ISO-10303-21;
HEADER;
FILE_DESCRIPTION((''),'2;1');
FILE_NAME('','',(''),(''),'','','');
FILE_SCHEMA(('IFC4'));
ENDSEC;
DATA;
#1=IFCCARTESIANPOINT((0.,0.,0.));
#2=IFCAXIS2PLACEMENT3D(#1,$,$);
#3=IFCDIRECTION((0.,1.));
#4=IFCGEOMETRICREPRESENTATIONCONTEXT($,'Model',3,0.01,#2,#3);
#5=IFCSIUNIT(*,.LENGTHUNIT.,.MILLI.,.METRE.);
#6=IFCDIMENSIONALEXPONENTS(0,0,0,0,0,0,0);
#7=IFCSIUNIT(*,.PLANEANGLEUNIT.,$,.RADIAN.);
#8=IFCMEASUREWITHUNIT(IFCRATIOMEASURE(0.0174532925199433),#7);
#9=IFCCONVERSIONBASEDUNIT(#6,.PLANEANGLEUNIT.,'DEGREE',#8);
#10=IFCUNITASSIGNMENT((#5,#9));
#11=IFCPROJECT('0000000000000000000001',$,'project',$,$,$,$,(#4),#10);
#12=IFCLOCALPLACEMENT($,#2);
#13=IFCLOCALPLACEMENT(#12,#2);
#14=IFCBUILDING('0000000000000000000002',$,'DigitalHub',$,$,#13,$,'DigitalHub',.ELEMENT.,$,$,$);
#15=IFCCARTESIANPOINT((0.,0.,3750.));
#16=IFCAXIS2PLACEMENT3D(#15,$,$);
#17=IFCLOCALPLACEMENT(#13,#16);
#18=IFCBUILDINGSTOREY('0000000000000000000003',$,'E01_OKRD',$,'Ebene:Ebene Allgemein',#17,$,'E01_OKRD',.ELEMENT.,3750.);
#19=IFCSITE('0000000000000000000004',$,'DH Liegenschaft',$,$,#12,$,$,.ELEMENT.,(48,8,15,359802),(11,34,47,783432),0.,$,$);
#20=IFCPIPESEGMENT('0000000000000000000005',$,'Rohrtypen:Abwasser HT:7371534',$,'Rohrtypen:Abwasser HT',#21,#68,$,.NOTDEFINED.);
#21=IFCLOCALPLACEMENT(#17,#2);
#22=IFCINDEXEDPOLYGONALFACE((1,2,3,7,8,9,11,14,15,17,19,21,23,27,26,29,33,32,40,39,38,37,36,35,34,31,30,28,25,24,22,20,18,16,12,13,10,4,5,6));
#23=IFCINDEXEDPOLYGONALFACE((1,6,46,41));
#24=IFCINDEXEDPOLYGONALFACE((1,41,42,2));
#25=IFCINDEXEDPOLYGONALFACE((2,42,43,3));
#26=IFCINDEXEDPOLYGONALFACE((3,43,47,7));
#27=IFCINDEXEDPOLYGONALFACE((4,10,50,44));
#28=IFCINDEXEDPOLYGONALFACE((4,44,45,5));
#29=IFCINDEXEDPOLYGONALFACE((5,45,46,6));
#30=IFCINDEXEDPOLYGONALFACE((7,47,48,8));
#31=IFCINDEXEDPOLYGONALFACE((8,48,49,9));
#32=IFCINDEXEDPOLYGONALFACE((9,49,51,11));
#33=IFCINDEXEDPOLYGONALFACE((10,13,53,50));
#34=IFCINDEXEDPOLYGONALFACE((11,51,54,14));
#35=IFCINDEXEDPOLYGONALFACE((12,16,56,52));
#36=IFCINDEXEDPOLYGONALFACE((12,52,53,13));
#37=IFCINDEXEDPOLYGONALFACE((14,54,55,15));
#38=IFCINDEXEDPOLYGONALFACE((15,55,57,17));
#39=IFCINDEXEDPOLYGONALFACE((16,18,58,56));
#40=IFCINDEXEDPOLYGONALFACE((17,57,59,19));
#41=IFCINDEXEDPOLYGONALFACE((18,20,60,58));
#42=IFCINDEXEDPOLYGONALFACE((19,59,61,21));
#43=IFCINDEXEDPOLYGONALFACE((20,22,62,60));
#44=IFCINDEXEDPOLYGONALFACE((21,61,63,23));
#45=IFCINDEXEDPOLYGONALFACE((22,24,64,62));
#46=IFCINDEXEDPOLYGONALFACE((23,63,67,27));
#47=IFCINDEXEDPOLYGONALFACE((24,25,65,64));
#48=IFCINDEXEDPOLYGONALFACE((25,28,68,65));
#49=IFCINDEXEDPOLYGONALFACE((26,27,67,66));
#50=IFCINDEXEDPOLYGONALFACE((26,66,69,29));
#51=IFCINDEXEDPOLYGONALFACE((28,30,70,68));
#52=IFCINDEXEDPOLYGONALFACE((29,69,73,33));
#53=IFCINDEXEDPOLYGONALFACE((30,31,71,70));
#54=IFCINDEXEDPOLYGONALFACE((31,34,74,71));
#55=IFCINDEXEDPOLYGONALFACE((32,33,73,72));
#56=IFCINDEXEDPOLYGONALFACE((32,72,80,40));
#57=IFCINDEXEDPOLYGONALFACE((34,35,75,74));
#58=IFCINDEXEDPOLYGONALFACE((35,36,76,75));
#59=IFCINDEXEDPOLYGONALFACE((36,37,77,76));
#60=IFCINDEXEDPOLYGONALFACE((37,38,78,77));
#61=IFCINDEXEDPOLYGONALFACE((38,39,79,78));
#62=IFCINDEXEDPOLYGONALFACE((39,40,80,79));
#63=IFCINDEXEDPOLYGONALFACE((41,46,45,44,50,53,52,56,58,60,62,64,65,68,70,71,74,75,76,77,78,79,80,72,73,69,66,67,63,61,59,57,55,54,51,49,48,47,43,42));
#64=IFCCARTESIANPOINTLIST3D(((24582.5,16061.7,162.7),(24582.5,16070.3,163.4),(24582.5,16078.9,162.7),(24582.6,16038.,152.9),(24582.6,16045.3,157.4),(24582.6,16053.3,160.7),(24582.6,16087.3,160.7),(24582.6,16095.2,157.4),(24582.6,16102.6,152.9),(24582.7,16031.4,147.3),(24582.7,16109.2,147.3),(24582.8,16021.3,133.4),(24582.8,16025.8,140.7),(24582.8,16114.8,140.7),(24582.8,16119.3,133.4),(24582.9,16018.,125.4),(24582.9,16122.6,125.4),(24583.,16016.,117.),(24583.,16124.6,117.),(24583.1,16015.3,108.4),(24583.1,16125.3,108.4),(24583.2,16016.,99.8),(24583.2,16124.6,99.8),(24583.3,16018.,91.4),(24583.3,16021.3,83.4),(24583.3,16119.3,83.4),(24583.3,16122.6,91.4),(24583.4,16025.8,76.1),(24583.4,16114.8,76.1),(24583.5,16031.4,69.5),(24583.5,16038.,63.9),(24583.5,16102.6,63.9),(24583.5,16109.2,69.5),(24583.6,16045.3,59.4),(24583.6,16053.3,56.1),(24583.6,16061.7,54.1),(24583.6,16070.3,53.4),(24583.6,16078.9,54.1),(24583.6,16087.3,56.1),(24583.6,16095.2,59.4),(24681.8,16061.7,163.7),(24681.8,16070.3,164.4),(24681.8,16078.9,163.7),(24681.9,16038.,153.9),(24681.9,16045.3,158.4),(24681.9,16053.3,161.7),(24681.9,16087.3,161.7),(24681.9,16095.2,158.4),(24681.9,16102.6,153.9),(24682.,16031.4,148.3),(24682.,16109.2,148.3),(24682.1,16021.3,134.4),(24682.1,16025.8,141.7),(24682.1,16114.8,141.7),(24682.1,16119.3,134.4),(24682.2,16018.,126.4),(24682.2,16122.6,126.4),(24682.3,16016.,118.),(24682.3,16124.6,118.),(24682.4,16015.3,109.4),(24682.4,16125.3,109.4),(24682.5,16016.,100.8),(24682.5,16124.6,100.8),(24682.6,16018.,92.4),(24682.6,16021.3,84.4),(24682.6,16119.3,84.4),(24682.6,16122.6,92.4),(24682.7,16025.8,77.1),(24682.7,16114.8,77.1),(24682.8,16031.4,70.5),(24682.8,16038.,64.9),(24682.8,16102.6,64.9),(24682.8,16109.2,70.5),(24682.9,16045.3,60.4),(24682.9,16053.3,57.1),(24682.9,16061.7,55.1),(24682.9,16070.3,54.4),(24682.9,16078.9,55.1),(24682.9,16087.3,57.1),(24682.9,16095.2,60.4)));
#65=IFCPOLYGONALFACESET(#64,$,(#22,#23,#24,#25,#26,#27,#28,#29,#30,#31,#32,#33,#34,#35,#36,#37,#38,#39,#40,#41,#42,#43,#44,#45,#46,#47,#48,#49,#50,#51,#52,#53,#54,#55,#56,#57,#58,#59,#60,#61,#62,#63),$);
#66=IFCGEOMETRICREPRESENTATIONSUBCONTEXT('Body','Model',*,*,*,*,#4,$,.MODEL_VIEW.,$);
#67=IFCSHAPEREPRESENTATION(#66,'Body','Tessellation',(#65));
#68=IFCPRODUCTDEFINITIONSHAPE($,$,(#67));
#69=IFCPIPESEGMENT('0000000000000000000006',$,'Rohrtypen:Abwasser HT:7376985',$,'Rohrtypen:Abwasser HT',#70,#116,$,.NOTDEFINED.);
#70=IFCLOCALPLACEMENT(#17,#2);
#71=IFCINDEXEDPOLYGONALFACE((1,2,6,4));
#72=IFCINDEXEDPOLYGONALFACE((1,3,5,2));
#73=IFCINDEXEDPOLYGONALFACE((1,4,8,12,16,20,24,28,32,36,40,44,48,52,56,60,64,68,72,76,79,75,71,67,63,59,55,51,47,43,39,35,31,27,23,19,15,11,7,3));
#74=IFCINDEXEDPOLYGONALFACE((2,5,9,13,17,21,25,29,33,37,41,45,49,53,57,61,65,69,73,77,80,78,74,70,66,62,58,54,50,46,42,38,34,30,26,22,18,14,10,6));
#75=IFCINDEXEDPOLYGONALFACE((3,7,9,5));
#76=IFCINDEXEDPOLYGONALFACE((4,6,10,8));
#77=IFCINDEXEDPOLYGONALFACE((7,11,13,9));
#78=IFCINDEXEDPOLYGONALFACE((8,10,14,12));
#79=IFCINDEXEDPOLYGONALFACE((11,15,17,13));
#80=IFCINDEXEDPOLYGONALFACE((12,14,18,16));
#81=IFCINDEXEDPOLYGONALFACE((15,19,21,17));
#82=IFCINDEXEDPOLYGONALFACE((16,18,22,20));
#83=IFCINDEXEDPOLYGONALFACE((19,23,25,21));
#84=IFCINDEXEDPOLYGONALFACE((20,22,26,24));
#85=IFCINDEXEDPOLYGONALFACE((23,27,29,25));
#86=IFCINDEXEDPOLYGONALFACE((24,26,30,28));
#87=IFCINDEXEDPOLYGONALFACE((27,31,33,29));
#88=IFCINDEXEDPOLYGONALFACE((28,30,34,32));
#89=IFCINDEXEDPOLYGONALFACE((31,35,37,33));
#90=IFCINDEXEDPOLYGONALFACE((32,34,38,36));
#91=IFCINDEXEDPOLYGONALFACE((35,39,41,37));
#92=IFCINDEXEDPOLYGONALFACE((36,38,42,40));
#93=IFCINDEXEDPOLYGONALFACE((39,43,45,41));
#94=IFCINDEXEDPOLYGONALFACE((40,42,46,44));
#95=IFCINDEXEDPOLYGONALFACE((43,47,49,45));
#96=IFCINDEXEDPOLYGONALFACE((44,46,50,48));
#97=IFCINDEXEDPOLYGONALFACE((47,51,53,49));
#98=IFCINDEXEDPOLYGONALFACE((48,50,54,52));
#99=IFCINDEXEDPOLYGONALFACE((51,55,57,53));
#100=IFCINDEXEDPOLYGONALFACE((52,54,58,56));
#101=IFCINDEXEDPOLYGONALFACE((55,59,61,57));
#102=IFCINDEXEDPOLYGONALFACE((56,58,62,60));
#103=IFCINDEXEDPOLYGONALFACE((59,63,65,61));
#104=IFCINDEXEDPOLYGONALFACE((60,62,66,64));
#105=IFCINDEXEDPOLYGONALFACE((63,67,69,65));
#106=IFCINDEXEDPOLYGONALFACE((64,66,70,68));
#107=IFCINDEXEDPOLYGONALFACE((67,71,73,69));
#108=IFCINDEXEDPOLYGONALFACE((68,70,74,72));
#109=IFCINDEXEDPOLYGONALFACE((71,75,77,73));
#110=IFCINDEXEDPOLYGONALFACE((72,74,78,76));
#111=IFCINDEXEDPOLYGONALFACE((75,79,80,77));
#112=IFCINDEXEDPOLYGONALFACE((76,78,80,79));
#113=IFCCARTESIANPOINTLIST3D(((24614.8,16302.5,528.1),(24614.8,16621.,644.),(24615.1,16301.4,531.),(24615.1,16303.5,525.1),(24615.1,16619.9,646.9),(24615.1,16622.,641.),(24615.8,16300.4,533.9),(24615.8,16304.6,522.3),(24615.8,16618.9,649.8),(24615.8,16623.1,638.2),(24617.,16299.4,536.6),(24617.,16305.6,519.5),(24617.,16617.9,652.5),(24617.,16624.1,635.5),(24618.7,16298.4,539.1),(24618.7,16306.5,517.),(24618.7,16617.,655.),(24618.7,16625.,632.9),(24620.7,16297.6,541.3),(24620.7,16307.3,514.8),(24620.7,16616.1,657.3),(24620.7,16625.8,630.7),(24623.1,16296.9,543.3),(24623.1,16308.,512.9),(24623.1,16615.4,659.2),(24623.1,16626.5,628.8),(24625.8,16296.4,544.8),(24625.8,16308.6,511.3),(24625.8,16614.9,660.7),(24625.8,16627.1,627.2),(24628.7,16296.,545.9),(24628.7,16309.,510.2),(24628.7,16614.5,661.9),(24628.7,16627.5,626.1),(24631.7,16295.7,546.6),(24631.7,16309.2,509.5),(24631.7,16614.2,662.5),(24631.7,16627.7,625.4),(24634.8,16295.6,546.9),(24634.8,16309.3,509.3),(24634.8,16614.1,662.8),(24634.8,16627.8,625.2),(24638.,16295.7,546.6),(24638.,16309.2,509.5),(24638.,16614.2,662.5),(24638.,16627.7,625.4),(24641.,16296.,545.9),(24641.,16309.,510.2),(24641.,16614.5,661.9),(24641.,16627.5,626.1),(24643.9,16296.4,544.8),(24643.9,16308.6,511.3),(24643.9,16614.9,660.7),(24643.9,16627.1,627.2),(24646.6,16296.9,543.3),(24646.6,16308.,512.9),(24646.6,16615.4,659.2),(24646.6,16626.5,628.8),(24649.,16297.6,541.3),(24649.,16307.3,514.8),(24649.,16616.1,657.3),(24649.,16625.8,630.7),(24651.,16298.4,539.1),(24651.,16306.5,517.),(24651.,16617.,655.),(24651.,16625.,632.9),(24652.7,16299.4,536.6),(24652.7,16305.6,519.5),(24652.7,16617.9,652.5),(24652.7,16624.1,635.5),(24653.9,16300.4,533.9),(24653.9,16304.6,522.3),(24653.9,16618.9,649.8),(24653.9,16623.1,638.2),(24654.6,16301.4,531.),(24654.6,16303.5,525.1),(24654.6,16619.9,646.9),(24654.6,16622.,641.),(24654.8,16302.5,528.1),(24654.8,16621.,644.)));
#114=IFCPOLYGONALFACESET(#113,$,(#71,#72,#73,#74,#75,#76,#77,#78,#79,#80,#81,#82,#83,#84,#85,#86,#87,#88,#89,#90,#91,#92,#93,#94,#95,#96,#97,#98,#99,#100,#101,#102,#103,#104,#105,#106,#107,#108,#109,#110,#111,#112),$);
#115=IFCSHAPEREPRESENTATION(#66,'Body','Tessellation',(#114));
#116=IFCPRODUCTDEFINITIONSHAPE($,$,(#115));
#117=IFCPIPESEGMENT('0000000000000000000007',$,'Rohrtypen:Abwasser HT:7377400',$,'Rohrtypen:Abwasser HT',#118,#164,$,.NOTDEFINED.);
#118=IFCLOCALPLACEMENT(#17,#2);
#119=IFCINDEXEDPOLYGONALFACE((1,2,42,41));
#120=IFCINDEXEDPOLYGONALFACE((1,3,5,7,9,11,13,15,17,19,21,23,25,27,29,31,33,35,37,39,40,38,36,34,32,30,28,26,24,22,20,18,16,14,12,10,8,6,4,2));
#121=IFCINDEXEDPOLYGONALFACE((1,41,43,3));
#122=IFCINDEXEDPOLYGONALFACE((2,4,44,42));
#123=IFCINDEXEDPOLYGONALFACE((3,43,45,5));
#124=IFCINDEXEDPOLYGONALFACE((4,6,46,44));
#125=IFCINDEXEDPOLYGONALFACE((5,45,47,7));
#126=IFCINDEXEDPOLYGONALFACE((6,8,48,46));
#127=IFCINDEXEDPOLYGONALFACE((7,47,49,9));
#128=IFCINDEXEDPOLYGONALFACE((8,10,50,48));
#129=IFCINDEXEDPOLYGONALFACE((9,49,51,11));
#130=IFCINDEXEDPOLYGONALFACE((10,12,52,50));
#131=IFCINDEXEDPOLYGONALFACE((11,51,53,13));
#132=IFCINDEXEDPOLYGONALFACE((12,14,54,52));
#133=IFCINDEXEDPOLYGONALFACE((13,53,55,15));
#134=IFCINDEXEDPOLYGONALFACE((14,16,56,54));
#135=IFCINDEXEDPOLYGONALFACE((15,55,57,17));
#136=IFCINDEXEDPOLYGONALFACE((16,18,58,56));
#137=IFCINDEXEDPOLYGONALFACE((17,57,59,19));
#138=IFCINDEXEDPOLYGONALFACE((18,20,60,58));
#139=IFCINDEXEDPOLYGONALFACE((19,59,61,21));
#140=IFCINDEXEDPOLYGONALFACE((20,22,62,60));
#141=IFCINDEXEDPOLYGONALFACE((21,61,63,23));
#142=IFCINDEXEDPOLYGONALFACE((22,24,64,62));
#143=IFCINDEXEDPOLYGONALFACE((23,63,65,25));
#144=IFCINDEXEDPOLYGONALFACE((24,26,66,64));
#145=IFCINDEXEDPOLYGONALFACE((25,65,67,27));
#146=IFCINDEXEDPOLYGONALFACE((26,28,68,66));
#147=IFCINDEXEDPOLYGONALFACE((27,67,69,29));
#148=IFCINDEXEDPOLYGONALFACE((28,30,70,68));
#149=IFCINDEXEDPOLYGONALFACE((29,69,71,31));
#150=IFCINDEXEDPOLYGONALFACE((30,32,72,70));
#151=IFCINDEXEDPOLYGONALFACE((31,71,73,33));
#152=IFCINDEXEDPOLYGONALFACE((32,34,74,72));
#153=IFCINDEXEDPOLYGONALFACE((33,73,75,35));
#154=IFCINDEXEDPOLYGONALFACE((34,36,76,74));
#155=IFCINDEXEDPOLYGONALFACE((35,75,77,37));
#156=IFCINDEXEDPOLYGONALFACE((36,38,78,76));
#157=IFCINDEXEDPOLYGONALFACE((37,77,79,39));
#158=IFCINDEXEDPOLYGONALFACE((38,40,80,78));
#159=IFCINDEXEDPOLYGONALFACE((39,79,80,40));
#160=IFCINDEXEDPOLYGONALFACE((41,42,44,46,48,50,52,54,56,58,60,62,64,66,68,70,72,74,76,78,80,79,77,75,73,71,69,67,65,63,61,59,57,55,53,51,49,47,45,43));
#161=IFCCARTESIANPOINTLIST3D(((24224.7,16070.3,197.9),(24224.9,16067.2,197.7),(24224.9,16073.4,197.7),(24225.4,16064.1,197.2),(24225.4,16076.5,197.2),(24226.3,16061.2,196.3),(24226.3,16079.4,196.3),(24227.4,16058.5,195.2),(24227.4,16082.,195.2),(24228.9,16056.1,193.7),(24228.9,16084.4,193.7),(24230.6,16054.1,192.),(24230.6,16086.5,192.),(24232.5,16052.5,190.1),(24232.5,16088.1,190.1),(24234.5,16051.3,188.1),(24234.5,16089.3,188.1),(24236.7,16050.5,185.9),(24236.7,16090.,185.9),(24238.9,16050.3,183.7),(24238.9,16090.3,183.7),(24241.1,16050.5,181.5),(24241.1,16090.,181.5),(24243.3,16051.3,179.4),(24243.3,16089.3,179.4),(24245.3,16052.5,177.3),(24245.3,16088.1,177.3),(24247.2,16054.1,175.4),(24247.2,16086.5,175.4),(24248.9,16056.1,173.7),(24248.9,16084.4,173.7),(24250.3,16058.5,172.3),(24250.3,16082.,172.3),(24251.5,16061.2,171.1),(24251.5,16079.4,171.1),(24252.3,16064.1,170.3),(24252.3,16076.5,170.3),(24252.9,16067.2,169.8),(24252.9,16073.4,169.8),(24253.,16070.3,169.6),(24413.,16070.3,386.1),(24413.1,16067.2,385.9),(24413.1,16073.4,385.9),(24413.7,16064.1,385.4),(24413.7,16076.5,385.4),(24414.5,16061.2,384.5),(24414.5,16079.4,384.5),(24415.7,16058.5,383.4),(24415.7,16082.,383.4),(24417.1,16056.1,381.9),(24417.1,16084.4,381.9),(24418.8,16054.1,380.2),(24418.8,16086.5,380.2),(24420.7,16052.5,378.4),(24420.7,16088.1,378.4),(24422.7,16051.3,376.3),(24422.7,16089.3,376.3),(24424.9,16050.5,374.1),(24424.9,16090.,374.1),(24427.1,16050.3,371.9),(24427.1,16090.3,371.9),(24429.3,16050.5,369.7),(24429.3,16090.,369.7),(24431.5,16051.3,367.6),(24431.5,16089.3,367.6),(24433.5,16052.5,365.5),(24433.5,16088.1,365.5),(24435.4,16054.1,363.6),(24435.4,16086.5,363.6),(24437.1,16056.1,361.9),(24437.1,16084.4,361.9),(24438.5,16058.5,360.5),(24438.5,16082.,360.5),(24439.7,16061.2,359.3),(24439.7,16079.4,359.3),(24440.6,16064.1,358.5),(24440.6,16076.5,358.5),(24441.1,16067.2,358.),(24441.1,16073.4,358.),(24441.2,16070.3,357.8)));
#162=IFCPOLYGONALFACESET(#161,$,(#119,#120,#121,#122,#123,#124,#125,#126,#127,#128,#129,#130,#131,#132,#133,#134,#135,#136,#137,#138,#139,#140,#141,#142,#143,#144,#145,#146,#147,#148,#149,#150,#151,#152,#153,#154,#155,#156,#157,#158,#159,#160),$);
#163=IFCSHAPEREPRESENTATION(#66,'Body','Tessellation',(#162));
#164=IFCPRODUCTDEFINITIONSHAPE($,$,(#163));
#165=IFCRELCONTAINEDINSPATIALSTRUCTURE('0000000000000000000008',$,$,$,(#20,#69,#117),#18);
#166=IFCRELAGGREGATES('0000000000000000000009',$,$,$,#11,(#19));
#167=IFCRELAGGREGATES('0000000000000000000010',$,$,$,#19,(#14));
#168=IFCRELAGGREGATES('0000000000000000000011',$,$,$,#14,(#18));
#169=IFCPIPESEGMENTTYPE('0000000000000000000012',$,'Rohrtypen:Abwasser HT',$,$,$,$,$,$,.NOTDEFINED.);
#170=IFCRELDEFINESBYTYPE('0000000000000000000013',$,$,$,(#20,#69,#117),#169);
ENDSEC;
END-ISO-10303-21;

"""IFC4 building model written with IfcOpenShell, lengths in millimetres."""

from ifc_helpers import new_model, entity, si_unit, converted_unit, direction, frame, origin, place, context, subcontext, project, spatial, indexed_curve, outline, extrude, type_object, element, save


model = new_model("IFC4")

# Units and contexts
model_context = context("Model", 3, precision=0.01, world=origin(), true_north=direction((0.0, 1.0)))
body_context = subcontext(model_context, "Body", "Model", "MODEL_VIEW")
ifc_project = project(units=[si_unit("LENGTHUNIT", "METRE", prefix="MILLI"), converted_unit("PLANEANGLEUNIT", "DEGREE", entity("IfcRatioMeasure", 0.0174532925199433), si_unit("PLANEANGLEUNIT", "RADIAN"), dimensions=[0, 0, 0, 0, 0, 0, 0])], contexts=[model_context])

# Site, building, storey
site_placement = place(None, origin())
site = spatial("IfcSite", under=ifc_project, at=site_placement, Name="DH Liegenschaft", CompositionType="ELEMENT", RefLatitude=(48, 8, 15, 359802), RefLongitude=(11, 34, 47, 783432), RefElevation=0.0)
building_placement = place(site_placement, origin())
building = spatial("IfcBuilding", under=site, at=building_placement, Name="DigitalHub", LongName="DigitalHub", CompositionType="ELEMENT")
storey_placement = place(building_placement, frame((0.0, 0.0, 3750.0)))
storey = spatial("IfcBuildingStorey", under=building, at=storey_placement, Name="E01_OKRD", ObjectType="Ebene:Ebene Allgemein", LongName="E01_OKRD", CompositionType="ELEMENT", Elevation=3750.0)

# Pipe segments
pipe_segment_type_1 = type_object("IfcPipeSegmentType", Name="Rohrtypen:Abwasser HT", PredefinedType="NOTDEFINED")
pipe_segment_1_placement = place(storey_placement, frame((24580.9, 16013.7, 51.8)))
element("IfcPipeSegment", 1, at=pipe_segment_1_placement, inside=storey, type_object=pipe_segment_type_1, Name="Rohrtypen:Abwasser HT:7371534", ObjectType="Rohrtypen:Abwasser HT", PredefinedType="NOTDEFINED", context=body_context, shape_type="SweptSolid", body=[
    extrude(outline(indexed_curve([(55.0, 0.0), (54.3, 8.6), (52.3, 17.0), (49.0, 25.0), (44.5, 32.3), (38.9, 38.9), (32.3, 44.5), (25.0, 49.0), (17.0, 52.3), (8.6, 54.3), (0.0, 55.0), (-8.6, 54.3), (-17.0, 52.3), (-25.0, 49.0), (-32.3, 44.5), (-38.9, 38.9), (-44.5, 32.3), (-49.0, 25.0), (-52.3, 17.0), (-54.3, 8.6), (-55.0, 0.0), (-54.3, -8.6), (-52.3, -17.0), (-49.0, -25.0), (-44.5, -32.3), (-38.9, -38.9), (-32.3, -44.5), (-25.0, -49.0), (-17.0, -52.3), (-8.6, -54.3), (0.0, -55.0), (8.6, -54.3), (17.0, -52.3), (25.0, -49.0), (32.3, -44.5), (38.9, -38.9), (44.5, -32.3), (49.0, -25.0), (52.3, -17.0), (54.3, -8.6), (55.0, 0.0)], self_intersect=False)), frame((2.1, 56.6, 56.6), z_axis=(0.99995, 0.0, 0.01), x_axis=(0.0, -1.0, 0.0)), (0.0, 0.0, 1.0), 99.3),
])
pipe_segment_2_placement = place(storey_placement, frame((24613.3, 16294.0, 507.7)))
element("IfcPipeSegment", 2, at=pipe_segment_2_placement, inside=storey, type_object=pipe_segment_type_1, Name="Rohrtypen:Abwasser HT:7376985", ObjectType="Rohrtypen:Abwasser HT", PredefinedType="NOTDEFINED", context=body_context, shape_type="SweptSolid", body=[
    extrude(outline(indexed_curve([(20.0, 0.0), (19.8, 3.1), (19.0, 6.2), (17.8, 9.1), (16.2, 11.8), (14.1, 14.1), (11.8, 16.2), (9.1, 17.8), (6.2, 19.0), (3.1, 19.8), (0.0, 20.0), (-3.1, 19.8), (-6.2, 19.0), (-9.1, 17.8), (-11.8, 16.2), (-14.1, 14.1), (-16.2, 11.8), (-17.8, 9.1), (-19.0, 6.2), (-19.8, 3.1), (-20.0, 0.0), (-19.8, -3.1), (-19.0, -6.2), (-17.8, -9.1), (-16.2, -11.8), (-14.1, -14.1), (-11.8, -16.2), (-9.1, -17.8), (-6.2, -19.0), (-3.1, -19.8), (0.0, -20.0), (3.1, -19.8), (6.2, -19.0), (9.1, -17.8), (11.8, -16.2), (14.1, -14.1), (16.2, -11.8), (17.8, -9.1), (19.0, -6.2), (19.8, -3.1), (20.0, 0.0)], self_intersect=False)), frame((21.6, 8.4, 20.4), z_axis=(0.0, 0.939693, 0.34202), x_axis=(-1.0, 0.0, 0.0)), (0.0, 0.0, 1.0), 339.0),
])
pipe_segment_3_placement = place(storey_placement, frame((24223.2, 16048.7, 168.0)))
element("IfcPipeSegment", 3, at=pipe_segment_3_placement, inside=storey, type_object=pipe_segment_type_1, Name="Rohrtypen:Abwasser HT:7377400", ObjectType="Rohrtypen:Abwasser HT", PredefinedType="NOTDEFINED", context=body_context, shape_type="SweptSolid", body=[
    extrude(outline(indexed_curve([(20.0, 0.0), (19.8, 3.1), (19.0, 6.2), (17.8, 9.1), (16.2, 11.8), (14.1, 14.1), (11.8, 16.2), (9.1, 17.8), (6.2, 19.0), (3.1, 19.8), (0.0, 20.0), (-3.1, 19.8), (-6.2, 19.0), (-9.1, 17.8), (-11.8, 16.2), (-14.1, 14.1), (-16.2, 11.8), (-17.8, 9.1), (-19.0, 6.2), (-19.8, 3.1), (-20.0, 0.0), (-19.8, -3.1), (-19.0, -6.2), (-17.8, -9.1), (-16.2, -11.8), (-14.1, -14.1), (-11.8, -16.2), (-9.1, -17.8), (-6.2, -19.0), (-3.1, -19.8), (0.0, -20.0), (3.1, -19.8), (6.2, -19.0), (9.1, -17.8), (11.8, -16.2), (14.1, -14.1), (16.2, -11.8), (17.8, -9.1), (19.0, -6.2), (19.8, -3.1), (20.0, 0.0)], self_intersect=False)), frame((15.7, 21.6, 15.7), z_axis=(0.707107, 0.0, 0.707107), x_axis=(0.0, -1.0, 0.0)), (0.0, 0.0, 1.0), 266.2),
])

save(model, "model.ifc")
